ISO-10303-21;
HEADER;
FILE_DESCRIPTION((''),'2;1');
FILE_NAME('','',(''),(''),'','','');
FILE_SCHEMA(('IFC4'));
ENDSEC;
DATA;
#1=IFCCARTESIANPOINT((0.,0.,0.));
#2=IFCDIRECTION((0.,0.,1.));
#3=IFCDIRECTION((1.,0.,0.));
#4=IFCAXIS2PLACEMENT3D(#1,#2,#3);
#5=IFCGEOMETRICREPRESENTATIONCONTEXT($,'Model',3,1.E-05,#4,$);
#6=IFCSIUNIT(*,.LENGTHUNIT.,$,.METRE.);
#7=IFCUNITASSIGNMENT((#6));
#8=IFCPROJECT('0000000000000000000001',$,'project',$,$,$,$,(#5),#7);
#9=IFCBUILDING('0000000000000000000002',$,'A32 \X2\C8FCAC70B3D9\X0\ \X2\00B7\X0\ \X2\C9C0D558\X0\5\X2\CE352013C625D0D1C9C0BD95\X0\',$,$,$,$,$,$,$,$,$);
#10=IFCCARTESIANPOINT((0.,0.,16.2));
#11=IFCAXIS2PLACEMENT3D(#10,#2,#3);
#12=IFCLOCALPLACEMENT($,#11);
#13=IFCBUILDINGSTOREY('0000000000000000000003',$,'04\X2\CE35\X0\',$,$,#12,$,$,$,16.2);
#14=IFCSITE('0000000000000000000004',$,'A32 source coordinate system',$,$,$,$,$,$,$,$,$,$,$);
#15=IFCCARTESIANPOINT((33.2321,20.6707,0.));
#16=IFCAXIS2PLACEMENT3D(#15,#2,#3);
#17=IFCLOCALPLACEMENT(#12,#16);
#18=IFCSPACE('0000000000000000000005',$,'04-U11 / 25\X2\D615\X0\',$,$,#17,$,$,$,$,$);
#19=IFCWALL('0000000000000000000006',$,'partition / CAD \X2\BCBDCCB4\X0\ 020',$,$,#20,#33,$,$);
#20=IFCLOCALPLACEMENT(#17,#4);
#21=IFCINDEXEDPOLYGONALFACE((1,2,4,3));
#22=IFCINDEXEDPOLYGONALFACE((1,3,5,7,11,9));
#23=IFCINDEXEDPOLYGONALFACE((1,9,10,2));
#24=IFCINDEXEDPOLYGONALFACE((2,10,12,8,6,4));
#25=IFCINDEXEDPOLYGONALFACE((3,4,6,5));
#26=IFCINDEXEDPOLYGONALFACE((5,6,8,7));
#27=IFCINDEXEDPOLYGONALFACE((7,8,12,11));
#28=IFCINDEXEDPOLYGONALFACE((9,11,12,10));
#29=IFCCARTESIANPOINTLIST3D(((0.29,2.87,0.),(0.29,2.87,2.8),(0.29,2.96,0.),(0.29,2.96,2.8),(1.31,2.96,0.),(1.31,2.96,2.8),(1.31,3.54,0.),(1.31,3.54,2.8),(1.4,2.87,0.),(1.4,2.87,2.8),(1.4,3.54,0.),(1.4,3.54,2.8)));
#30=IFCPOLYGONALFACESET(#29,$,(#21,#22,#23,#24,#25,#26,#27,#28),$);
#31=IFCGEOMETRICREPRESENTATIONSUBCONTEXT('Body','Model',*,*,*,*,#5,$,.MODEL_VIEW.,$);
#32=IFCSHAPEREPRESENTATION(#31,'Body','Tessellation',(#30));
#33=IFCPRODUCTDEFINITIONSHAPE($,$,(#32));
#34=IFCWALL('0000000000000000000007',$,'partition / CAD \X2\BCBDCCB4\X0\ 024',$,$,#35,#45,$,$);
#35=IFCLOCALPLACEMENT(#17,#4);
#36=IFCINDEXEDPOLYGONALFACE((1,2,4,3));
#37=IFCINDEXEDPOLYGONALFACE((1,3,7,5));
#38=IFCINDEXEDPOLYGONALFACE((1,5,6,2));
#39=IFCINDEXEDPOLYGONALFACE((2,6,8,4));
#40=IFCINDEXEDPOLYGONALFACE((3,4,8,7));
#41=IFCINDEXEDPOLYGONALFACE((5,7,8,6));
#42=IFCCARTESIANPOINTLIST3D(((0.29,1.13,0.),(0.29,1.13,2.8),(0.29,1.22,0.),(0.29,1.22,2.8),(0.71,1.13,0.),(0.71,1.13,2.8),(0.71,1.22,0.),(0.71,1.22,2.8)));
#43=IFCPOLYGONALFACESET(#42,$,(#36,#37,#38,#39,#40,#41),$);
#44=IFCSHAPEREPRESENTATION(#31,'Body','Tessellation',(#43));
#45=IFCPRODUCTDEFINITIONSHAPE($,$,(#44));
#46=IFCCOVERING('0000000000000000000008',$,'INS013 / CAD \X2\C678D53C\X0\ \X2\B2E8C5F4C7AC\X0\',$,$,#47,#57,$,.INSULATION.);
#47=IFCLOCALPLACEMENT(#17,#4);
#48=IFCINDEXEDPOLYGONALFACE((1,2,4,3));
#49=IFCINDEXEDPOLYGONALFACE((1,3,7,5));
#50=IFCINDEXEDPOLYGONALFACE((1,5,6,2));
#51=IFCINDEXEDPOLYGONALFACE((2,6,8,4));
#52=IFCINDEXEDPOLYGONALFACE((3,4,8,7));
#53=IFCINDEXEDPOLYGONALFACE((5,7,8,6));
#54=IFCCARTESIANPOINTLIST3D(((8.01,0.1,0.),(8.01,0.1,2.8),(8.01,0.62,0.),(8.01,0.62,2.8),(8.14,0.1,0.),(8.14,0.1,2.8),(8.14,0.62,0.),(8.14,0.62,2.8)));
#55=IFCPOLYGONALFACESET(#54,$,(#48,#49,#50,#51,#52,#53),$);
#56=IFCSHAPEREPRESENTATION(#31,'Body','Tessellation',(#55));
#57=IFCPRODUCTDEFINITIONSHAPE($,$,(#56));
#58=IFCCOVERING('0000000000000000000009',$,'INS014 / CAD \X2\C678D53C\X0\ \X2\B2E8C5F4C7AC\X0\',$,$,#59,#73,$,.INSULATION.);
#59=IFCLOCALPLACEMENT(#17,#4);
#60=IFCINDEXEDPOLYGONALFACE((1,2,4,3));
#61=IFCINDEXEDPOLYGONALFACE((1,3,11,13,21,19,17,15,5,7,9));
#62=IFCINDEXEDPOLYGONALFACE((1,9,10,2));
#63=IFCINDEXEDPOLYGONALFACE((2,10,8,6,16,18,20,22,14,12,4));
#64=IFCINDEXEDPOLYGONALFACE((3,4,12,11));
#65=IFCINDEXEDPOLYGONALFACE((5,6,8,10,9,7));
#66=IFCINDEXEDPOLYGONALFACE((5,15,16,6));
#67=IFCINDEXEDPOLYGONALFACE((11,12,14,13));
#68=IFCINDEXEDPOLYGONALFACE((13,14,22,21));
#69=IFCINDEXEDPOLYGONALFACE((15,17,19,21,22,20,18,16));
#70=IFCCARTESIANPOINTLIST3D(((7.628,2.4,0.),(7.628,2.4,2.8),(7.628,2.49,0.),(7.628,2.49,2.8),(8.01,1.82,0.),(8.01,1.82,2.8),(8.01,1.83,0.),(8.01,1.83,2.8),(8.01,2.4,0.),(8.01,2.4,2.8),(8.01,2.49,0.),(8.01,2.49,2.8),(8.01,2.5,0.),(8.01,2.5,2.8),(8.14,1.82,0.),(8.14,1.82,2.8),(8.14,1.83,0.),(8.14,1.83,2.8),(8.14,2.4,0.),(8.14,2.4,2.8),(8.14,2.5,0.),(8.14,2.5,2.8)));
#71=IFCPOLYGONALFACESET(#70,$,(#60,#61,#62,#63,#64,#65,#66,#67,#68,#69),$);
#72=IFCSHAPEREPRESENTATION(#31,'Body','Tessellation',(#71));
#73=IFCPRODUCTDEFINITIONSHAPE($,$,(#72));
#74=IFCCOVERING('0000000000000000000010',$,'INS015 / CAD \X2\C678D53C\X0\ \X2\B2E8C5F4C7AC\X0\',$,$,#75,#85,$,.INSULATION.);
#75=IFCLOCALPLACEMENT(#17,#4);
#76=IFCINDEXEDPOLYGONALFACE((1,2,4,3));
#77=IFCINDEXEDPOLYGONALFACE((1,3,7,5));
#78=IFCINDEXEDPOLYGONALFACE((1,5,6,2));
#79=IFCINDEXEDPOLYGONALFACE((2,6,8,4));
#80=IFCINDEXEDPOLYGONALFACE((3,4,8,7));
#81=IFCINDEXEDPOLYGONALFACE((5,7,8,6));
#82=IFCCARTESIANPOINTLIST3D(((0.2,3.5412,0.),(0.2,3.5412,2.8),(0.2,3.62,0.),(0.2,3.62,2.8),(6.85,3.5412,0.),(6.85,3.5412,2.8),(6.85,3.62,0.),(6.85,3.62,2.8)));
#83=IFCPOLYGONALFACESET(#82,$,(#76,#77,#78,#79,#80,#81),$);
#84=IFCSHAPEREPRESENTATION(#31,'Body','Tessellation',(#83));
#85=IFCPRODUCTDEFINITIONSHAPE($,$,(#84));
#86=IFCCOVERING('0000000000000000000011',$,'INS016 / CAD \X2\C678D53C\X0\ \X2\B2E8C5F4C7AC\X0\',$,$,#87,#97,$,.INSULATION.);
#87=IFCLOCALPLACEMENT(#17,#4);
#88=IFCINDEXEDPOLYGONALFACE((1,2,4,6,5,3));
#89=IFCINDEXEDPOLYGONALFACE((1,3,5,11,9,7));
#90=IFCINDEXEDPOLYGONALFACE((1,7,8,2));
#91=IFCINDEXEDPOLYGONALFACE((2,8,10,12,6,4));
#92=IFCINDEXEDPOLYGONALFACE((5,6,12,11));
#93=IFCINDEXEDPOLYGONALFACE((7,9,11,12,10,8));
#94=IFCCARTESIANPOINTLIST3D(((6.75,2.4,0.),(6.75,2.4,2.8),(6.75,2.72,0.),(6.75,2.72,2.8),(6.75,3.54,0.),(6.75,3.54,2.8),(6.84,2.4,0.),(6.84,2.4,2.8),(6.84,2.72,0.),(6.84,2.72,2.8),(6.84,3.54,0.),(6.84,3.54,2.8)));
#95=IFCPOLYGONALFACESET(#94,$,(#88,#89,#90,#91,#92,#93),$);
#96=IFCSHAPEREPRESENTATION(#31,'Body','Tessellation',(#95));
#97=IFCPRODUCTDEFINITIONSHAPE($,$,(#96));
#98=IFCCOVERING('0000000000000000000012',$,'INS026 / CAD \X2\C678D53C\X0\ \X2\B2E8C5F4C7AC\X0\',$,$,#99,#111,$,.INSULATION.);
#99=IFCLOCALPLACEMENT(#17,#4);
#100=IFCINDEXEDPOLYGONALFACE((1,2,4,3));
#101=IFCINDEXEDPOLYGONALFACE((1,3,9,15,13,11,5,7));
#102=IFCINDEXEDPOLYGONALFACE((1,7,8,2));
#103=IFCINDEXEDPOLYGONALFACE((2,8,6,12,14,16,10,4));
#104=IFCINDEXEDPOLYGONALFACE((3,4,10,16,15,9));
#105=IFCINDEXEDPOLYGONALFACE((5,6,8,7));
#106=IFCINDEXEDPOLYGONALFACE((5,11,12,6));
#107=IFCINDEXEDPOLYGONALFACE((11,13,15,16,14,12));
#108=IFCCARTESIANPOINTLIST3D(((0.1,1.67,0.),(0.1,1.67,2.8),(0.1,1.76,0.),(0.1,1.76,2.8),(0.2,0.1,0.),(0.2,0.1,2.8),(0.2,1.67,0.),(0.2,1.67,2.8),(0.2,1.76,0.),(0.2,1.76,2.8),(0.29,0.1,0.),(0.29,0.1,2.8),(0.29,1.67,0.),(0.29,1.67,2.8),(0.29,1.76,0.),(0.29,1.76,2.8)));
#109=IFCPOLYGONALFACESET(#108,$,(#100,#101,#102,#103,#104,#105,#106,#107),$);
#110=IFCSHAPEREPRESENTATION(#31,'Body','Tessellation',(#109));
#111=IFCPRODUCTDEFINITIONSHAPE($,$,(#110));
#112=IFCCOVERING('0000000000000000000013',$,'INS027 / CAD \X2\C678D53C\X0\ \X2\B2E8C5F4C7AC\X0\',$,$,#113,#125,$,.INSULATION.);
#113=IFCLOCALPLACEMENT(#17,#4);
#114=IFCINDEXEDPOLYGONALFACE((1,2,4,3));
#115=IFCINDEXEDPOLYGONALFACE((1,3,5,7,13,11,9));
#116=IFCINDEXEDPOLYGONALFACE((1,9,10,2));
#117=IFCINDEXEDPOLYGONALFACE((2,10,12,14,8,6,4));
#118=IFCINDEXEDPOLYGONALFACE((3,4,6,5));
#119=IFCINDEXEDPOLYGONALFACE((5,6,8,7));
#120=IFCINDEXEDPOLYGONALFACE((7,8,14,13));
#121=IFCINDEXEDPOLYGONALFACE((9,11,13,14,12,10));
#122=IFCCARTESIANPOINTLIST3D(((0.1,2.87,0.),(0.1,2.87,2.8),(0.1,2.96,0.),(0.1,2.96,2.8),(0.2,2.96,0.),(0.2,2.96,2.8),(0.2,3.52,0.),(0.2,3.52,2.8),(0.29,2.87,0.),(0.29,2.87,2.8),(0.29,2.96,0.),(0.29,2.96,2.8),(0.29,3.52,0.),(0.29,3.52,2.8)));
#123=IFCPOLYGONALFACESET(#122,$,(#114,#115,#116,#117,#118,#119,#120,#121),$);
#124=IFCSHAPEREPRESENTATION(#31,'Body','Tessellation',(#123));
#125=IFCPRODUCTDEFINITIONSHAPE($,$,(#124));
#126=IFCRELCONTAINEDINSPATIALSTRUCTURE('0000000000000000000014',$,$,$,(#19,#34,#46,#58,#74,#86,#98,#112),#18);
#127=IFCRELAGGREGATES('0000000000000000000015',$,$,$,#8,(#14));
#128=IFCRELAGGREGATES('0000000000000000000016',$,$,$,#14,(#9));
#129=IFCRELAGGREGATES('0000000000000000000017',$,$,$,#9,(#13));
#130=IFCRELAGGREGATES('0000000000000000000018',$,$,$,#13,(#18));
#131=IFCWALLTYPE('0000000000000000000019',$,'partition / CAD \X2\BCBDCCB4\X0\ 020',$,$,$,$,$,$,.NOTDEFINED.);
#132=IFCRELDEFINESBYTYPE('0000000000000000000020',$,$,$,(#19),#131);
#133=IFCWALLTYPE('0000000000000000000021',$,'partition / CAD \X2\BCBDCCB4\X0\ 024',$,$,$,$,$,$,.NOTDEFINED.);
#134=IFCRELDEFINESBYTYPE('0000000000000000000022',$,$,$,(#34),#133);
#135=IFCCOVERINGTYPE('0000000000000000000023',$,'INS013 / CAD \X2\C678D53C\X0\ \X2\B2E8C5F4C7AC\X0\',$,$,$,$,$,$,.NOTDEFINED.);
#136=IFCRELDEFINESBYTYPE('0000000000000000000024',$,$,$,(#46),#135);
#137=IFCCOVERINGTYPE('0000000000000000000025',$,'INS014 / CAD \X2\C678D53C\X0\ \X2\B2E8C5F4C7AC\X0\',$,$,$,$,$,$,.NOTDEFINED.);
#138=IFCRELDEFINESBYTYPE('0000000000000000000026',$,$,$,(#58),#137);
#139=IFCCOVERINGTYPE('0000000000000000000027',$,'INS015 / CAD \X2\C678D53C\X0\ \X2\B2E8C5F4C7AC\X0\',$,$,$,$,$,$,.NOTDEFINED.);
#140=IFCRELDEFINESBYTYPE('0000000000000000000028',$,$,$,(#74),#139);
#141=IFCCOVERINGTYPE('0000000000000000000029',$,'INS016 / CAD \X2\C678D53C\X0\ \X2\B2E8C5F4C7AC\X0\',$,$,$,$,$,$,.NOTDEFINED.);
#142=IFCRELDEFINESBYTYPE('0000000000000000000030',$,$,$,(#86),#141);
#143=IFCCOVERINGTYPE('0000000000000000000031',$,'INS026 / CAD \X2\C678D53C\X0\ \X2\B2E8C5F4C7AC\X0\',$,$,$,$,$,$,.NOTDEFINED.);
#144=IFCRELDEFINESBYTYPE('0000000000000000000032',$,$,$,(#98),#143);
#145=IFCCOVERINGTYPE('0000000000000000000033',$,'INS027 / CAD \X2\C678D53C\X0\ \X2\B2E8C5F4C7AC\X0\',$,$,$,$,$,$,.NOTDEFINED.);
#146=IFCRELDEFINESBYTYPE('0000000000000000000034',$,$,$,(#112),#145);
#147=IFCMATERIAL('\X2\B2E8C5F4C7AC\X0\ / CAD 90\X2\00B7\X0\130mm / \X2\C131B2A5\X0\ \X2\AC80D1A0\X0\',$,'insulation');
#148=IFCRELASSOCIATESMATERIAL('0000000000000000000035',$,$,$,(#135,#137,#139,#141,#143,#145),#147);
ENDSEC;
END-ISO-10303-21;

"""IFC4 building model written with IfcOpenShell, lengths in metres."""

from ifc_helpers import new_model, si_unit, frame, origin, origin_with_axes, place, context, subcontext, project, spatial, polyline, outline, extrude, source, transform, mapped, material, type_object, type_shapes, element, save


model = new_model("IFC4")

# Units and contexts
model_context = context("Model", 3, precision=1e-05, world=origin_with_axes())
body_context = subcontext(model_context, "Body", "Model", "MODEL_VIEW")
ifc_project = project(units=[si_unit("LENGTHUNIT", "METRE")], contexts=[model_context])

# Site, building, storey, space
storey_placement = place(None, frame((0.0, 0.0, 16.2), z_axis=(0.0, 0.0, 1.0), x_axis=(1.0, 0.0, 0.0)))
space_placement = place(storey_placement, frame((33.2321, 20.6707, 0.0), z_axis=(0.0, 0.0, 1.0), x_axis=(1.0, 0.0, 0.0)))
site = spatial("IfcSite", under=ifc_project, Name="A32 source coordinate system")
building = spatial("IfcBuilding", under=site, Name="A32 주거동 · 지하5층–옥탑지붕")
storey = spatial("IfcBuildingStorey", under=building, at=storey_placement, Name="04층", Elevation=16.2)
space = spatial("IfcSpace", under=storey, at=space_placement, Name="04-U11 / 25형")

# Walls
wall_type_1 = type_object("IfcWallType", Name="partition / CAD 벽체 020", PredefinedType="NOTDEFINED")
shared_shape_1 = source(origin(), body_context, "Body", "SweptSolid", [
    extrude(outline(polyline([(0.29, 2.87), (0.29, 2.96), (1.31, 2.96), (1.31, 3.54), (1.4, 3.54), (1.4, 2.87), (0.29, 2.87)])), origin(), (0.0, 0.0, 1.0), 2.8),
])
type_shapes(wall_type_1, [shared_shape_1])
wall_1_placement = place(space_placement, origin_with_axes())
element("IfcWall", 1, at=wall_1_placement, inside=space, type_object=wall_type_1, Name="partition / CAD 벽체 020", context=body_context, shape_type="MappedRepresentation", body=[
    mapped(shared_shape_1, transform((0.0, 0.0, 0.0), scale=1.0)),
])
wall_type_2 = type_object("IfcWallType", Name="partition / CAD 벽체 024", PredefinedType="NOTDEFINED")
shared_shape_2 = source(origin(), body_context, "Body", "SweptSolid", [
    extrude(outline(polyline([(0.71, 1.13), (0.29, 1.13), (0.29, 1.22), (0.71, 1.22), (0.71, 1.13)])), origin(), (0.0, 0.0, 1.0), 2.8),
])
type_shapes(wall_type_2, [shared_shape_2])
wall_2_placement = place(space_placement, origin_with_axes())
element("IfcWall", 2, at=wall_2_placement, inside=space, type_object=wall_type_2, Name="partition / CAD 벽체 024", context=body_context, shape_type="MappedRepresentation", body=[
    mapped(shared_shape_2, transform((0.0, 0.0, 0.0), scale=1.0)),
])

# Coverings
ifc_material = material(Name="단열재 / CAD 90·130mm / 성능 검토", Category="insulation")
covering_type_1 = type_object("IfcCoveringType", Name="INS013 / CAD 외피 단열재", PredefinedType="NOTDEFINED", material=ifc_material)
shared_shape_3 = source(origin(), body_context, "Body", "SweptSolid", [
    extrude(outline(polyline([(8.14, 0.1), (8.01, 0.1), (8.01, 0.62), (8.14, 0.62), (8.14, 0.1)])), origin(), (0.0, 0.0, 1.0), 2.8),
])
type_shapes(covering_type_1, [shared_shape_3])
covering_1_placement = place(space_placement, origin_with_axes())
element("IfcCovering", 3, at=covering_1_placement, inside=space, type_object=covering_type_1, Name="INS013 / CAD 외피 단열재", PredefinedType="INSULATION", context=body_context, shape_type="MappedRepresentation", body=[
    mapped(shared_shape_3, transform((0.0, 0.0, 0.0), scale=1.0)),
])
covering_type_2 = type_object("IfcCoveringType", Name="INS014 / CAD 외피 단열재", PredefinedType="NOTDEFINED", material=ifc_material)
shared_shape_4 = source(origin(), body_context, "Body", "SweptSolid", [
    extrude(outline(polyline([(8.14, 2.5), (8.14, 2.4), (8.14, 1.83), (8.14, 1.82), (8.01, 1.82), (8.01, 1.83), (8.01, 2.4), (7.628, 2.4), (7.628, 2.49), (8.01, 2.49), (8.01, 2.5), (8.14, 2.5)])), origin(), (0.0, 0.0, 1.0), 2.8),
])
type_shapes(covering_type_2, [shared_shape_4])
covering_2_placement = place(space_placement, origin_with_axes())
element("IfcCovering", 4, at=covering_2_placement, inside=space, type_object=covering_type_2, Name="INS014 / CAD 외피 단열재", PredefinedType="INSULATION", context=body_context, shape_type="MappedRepresentation", body=[
    mapped(shared_shape_4, transform((0.0, 0.0, 0.0), scale=1.0)),
])
covering_type_3 = type_object("IfcCoveringType", Name="INS015 / CAD 외피 단열재", PredefinedType="NOTDEFINED", material=ifc_material)
shared_shape_5 = source(origin(), body_context, "Body", "SweptSolid", [
    extrude(outline(polyline([(0.2, 3.5412), (0.2, 3.62), (6.85, 3.62), (6.85, 3.5412), (0.2, 3.5412)])), origin(), (0.0, 0.0, 1.0), 2.8),
])
type_shapes(covering_type_3, [shared_shape_5])
covering_3_placement = place(space_placement, origin_with_axes())
element("IfcCovering", 5, at=covering_3_placement, inside=space, type_object=covering_type_3, Name="INS015 / CAD 외피 단열재", PredefinedType="INSULATION", context=body_context, shape_type="MappedRepresentation", body=[
    mapped(shared_shape_5, transform((0.0, 0.0, 0.0), scale=1.0)),
])
covering_type_4 = type_object("IfcCoveringType", Name="INS016 / CAD 외피 단열재", PredefinedType="NOTDEFINED", material=ifc_material)
shared_shape_6 = source(origin(), body_context, "Body", "SweptSolid", [
    extrude(outline(polyline([(6.84, 2.72), (6.84, 2.4), (6.75, 2.4), (6.75, 2.72), (6.75, 3.54), (6.84, 3.54), (6.84, 2.72)])), origin(), (0.0, 0.0, 1.0), 2.8),
])
type_shapes(covering_type_4, [shared_shape_6])
covering_4_placement = place(space_placement, origin_with_axes())
element("IfcCovering", 6, at=covering_4_placement, inside=space, type_object=covering_type_4, Name="INS016 / CAD 외피 단열재", PredefinedType="INSULATION", context=body_context, shape_type="MappedRepresentation", body=[
    mapped(shared_shape_6, transform((0.0, 0.0, 0.0), scale=1.0)),
])
covering_type_5 = type_object("IfcCoveringType", Name="INS026 / CAD 외피 단열재", PredefinedType="NOTDEFINED", material=ifc_material)
shared_shape_7 = source(origin(), body_context, "Body", "SweptSolid", [
    extrude(outline(polyline([(0.2, 1.76), (0.29, 1.76), (0.29, 1.67), (0.29, 0.1), (0.2, 0.1), (0.2, 1.67), (0.1, 1.67), (0.1, 1.76), (0.2, 1.76)])), origin(), (0.0, 0.0, 1.0), 2.8),
])
type_shapes(covering_type_5, [shared_shape_7])
covering_5_placement = place(space_placement, origin_with_axes())
element("IfcCovering", 7, at=covering_5_placement, inside=space, type_object=covering_type_5, Name="INS026 / CAD 외피 단열재", PredefinedType="INSULATION", context=body_context, shape_type="MappedRepresentation", body=[
    mapped(shared_shape_7, transform((0.0, 0.0, 0.0), scale=1.0)),
])
covering_type_6 = type_object("IfcCoveringType", Name="INS027 / CAD 외피 단열재", PredefinedType="NOTDEFINED", material=ifc_material)
shared_shape_8 = source(origin(), body_context, "Body", "SweptSolid", [
    extrude(outline(polyline([(0.2, 3.52), (0.29, 3.52), (0.29, 2.96), (0.29, 2.87), (0.1, 2.87), (0.1, 2.96), (0.2, 2.96), (0.2, 3.52)])), origin(), (0.0, 0.0, 1.0), 2.8),
])
type_shapes(covering_type_6, [shared_shape_8])
covering_6_placement = place(space_placement, origin_with_axes())
element("IfcCovering", 8, at=covering_6_placement, inside=space, type_object=covering_type_6, Name="INS027 / CAD 외피 단열재", PredefinedType="INSULATION", context=body_context, shape_type="MappedRepresentation", body=[
    mapped(shared_shape_8, transform((0.0, 0.0, 0.0), scale=1.0)),
])

save(model, "model.ifc")
